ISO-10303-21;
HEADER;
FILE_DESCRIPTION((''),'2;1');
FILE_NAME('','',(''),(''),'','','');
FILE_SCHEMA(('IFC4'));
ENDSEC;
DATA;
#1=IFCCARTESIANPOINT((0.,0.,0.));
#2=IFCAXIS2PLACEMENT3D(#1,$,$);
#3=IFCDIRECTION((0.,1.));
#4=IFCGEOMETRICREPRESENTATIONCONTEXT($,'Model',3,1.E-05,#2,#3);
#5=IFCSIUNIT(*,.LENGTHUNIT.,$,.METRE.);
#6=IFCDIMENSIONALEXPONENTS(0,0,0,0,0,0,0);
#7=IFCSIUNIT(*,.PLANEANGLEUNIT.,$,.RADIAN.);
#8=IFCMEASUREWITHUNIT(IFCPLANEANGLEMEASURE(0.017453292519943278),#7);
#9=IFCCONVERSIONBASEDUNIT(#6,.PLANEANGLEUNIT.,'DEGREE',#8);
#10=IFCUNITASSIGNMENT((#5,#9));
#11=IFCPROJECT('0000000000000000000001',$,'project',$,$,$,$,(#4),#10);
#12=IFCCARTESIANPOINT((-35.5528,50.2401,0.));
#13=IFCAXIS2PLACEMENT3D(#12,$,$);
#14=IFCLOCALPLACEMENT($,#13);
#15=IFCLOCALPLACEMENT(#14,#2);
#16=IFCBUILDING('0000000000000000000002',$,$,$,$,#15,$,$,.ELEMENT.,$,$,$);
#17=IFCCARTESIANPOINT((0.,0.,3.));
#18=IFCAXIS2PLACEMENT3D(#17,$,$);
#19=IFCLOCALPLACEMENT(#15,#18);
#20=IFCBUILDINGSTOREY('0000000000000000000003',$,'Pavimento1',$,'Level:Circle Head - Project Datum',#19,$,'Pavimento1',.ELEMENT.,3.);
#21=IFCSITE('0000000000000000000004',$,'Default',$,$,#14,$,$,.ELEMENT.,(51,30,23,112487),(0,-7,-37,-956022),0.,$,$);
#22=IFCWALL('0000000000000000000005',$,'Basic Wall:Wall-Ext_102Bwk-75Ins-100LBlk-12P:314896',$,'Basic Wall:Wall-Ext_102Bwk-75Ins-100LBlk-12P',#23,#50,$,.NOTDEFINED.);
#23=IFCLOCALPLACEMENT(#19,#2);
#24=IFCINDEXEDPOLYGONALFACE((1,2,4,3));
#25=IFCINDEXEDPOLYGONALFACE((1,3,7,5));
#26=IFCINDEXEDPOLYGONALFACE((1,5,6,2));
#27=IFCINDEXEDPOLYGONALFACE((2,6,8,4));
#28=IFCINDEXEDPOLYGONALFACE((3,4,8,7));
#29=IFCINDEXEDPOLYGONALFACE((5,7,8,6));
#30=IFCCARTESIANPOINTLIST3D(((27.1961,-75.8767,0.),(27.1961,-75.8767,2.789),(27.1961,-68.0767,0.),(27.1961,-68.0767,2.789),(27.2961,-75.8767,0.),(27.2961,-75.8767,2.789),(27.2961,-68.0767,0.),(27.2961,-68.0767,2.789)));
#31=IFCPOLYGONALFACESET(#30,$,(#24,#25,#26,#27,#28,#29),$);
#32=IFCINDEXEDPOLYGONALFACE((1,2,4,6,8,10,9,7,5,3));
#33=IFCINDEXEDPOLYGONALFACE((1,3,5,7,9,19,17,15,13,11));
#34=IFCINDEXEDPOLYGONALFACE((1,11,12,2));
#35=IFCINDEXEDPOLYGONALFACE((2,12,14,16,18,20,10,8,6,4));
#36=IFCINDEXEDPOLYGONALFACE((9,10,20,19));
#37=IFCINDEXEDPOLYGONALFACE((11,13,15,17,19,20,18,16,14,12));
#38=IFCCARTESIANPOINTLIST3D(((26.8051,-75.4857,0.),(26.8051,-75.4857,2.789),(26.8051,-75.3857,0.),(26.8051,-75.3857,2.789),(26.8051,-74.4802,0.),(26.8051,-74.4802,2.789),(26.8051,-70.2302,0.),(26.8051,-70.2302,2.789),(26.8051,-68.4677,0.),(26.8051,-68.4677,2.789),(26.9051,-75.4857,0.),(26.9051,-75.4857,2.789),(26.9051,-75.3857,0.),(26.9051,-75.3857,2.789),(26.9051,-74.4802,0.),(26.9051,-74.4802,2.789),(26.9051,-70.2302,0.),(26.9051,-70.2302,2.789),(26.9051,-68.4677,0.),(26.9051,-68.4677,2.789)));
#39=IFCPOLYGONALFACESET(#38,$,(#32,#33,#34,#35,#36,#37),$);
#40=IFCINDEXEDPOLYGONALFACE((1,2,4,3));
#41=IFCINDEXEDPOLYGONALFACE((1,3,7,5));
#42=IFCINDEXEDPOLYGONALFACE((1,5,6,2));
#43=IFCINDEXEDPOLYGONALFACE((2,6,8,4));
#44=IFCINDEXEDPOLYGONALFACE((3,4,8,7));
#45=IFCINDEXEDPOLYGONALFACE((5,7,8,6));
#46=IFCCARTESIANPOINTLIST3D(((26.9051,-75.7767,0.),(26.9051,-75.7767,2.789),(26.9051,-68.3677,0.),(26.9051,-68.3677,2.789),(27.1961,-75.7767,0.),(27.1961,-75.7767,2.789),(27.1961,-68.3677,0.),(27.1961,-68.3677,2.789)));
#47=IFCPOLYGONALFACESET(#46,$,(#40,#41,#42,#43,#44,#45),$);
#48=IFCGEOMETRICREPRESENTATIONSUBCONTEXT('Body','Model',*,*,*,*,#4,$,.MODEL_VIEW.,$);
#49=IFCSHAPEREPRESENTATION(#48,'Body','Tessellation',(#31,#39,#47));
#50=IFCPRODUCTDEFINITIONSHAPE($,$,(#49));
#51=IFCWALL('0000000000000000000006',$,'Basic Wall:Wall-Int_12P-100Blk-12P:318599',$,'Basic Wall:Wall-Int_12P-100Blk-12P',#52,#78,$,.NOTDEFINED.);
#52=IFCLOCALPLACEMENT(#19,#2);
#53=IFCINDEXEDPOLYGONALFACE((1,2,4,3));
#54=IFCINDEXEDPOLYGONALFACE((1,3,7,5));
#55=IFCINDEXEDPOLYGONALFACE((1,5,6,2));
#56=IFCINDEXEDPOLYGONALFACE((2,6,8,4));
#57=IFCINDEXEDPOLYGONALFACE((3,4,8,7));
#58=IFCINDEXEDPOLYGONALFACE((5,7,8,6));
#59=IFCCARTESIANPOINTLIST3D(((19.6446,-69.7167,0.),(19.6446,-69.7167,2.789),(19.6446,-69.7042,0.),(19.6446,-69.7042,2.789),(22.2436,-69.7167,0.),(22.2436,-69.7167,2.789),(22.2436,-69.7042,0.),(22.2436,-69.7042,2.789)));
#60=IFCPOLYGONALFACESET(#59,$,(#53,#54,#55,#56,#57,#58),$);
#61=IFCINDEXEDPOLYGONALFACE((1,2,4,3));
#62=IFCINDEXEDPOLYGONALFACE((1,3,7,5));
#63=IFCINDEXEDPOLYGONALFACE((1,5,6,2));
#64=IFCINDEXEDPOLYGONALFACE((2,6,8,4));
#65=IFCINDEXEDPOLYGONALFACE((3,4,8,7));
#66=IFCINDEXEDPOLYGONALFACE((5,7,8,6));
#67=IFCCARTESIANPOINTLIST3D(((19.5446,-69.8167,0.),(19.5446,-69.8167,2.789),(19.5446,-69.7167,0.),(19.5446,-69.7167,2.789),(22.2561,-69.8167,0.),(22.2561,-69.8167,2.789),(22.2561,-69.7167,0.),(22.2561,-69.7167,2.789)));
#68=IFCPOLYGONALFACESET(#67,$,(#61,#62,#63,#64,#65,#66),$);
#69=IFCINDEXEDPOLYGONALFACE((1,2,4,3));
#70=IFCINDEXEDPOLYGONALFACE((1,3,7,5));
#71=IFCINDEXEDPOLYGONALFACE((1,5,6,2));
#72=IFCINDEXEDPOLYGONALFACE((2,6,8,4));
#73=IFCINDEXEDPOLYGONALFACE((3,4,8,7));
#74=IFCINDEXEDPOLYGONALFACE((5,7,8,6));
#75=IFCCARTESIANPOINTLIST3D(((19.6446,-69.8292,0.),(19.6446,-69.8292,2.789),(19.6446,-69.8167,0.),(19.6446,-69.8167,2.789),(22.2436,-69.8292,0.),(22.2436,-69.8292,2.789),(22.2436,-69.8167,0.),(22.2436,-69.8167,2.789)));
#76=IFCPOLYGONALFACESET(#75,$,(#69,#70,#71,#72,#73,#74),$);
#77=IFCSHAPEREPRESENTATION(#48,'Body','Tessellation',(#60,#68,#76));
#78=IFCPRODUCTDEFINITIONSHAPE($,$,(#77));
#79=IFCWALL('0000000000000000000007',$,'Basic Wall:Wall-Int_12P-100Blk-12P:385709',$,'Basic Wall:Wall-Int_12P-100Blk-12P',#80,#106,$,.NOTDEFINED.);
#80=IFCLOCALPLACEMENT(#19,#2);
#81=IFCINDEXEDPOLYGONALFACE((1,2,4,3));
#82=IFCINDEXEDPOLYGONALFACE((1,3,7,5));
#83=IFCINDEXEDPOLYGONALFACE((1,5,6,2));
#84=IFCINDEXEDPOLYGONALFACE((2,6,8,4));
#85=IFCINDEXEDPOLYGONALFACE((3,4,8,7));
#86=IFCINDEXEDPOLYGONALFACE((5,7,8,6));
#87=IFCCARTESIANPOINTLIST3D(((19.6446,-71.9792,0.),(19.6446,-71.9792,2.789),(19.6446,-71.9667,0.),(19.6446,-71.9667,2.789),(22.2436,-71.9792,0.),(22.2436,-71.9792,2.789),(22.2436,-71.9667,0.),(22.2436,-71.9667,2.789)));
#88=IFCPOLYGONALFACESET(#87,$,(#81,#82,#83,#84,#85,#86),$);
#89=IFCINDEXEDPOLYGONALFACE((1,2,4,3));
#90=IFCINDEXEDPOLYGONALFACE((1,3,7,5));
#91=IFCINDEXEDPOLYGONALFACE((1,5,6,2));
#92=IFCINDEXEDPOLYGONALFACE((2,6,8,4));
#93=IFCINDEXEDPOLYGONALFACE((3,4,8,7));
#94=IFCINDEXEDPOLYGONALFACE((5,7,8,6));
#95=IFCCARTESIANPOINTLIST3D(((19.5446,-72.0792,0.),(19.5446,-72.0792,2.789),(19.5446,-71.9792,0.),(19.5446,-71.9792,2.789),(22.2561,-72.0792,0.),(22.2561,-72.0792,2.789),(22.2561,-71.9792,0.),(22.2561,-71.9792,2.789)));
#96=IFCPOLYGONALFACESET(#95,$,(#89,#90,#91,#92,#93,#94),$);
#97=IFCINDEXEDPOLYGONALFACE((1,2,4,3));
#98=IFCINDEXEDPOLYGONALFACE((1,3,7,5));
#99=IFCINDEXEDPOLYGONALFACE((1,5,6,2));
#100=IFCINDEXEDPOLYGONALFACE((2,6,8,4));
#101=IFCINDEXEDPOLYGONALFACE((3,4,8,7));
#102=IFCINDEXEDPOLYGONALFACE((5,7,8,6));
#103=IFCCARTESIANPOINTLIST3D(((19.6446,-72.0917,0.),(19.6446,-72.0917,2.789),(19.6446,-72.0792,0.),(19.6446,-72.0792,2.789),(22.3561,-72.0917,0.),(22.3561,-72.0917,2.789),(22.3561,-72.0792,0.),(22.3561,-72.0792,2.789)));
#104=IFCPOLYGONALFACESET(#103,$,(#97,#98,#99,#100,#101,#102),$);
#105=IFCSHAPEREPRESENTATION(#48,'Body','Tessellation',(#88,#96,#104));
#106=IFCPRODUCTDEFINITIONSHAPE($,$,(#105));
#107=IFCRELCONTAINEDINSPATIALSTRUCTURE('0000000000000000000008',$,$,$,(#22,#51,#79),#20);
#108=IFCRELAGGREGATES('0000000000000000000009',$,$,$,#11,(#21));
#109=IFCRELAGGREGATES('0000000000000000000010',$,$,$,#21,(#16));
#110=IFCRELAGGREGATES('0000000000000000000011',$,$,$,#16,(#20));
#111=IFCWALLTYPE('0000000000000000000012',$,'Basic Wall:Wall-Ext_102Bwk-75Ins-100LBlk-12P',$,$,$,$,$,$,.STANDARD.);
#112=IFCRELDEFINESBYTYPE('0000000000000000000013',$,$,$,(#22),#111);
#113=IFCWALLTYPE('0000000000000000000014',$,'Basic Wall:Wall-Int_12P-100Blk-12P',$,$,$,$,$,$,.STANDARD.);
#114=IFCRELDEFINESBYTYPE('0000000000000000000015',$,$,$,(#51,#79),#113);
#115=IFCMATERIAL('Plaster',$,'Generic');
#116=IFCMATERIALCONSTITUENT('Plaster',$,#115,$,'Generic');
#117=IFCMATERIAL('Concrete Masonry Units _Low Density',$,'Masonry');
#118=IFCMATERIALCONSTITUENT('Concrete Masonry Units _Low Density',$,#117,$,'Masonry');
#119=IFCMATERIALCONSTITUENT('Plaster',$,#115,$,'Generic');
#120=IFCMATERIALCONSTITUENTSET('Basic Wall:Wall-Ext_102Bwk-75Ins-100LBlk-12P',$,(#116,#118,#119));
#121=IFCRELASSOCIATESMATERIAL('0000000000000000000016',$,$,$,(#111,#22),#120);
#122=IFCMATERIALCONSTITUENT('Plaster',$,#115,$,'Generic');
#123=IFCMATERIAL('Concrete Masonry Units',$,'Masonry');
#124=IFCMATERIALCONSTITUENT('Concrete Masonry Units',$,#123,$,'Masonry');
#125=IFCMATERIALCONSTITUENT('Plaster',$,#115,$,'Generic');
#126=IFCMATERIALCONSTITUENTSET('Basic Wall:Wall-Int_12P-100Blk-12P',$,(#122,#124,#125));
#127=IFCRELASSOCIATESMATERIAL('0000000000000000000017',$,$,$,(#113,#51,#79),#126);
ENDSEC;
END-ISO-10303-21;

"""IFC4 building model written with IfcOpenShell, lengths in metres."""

from ifc_helpers import new_model, entity, si_unit, converted_unit, direction, frame, origin, place, context, subcontext, project, spatial, indexed_curve, outline, extrude, material, constituent, constituent_set, type_object, element, save


model = new_model("IFC4")

# Units and contexts
model_context = context("Model", 3, precision=1e-05, world=origin(), true_north=direction((0.0, 1.0)))
body_context = subcontext(model_context, "Body", "Model", "MODEL_VIEW")
ifc_project = project(units=[si_unit("LENGTHUNIT", "METRE"), converted_unit("PLANEANGLEUNIT", "DEGREE", entity("IfcPlaneAngleMeasure", 0.017453292519943278), si_unit("PLANEANGLEUNIT", "RADIAN"), dimensions=[0, 0, 0, 0, 0, 0, 0])], contexts=[model_context])

# Site, building, storey
site_placement = place(None, frame((-35.5528, 50.2401, 0.0)))
site = spatial("IfcSite", under=ifc_project, at=site_placement, Name="Default", CompositionType="ELEMENT", RefLatitude=(51, 30, 23, 112487), RefLongitude=(0, -7, -37, -956022), RefElevation=0.0)
building_placement = place(site_placement, origin())
building = spatial("IfcBuilding", under=site, at=building_placement, CompositionType="ELEMENT")
storey_placement = place(building_placement, frame((0.0, 0.0, 3.0)))
storey = spatial("IfcBuildingStorey", under=building, at=storey_placement, Name="Pavimento1", ObjectType="Level:Circle Head - Project Datum", LongName="Pavimento1", CompositionType="ELEMENT", Elevation=3.0)

# Wall
ifc_material_1 = material(Name="Plaster", Category="Generic")
ifc_constituent_1 = constituent(ifc_material_1, Name="Plaster", Category="Generic")
ifc_material_2 = material(Name="Concrete Masonry Units _Low Density", Category="Masonry")
ifc_constituent_2 = constituent(ifc_material_2, Name="Concrete Masonry Units _Low Density", Category="Masonry")
ifc_constituent_3 = constituent(ifc_material_1, Name="Plaster", Category="Generic")
ifc_constituent_set_1 = constituent_set(constituents=[ifc_constituent_1, ifc_constituent_2, ifc_constituent_3], Name="Basic Wall:Wall-Ext_102Bwk-75Ins-100LBlk-12P")
wall_type_1 = type_object("IfcWallType", Name="Basic Wall:Wall-Ext_102Bwk-75Ins-100LBlk-12P", PredefinedType="STANDARD", material=ifc_constituent_set_1)
wall_1_placement = place(storey_placement, frame((27.0506, -68.4677, 0.0), z_axis=(0.0, 0.0, 1.0), x_axis=(0.0, -1.0, 0.0)))
element("IfcWall", 1, at=wall_1_placement, inside=storey, type_object=wall_type_1, material=ifc_constituent_set_1, Name="Basic Wall:Wall-Ext_102Bwk-75Ins-100LBlk-12P:314896", ObjectType="Basic Wall:Wall-Ext_102Bwk-75Ins-100LBlk-12P", PredefinedType="NOTDEFINED", context=body_context, shape_type="SweptSolid", body=[
    extrude(outline(indexed_curve([(-1.3945, -3.9), (1.3945, -3.9), (1.3945, 3.9), (-1.3945, 3.9), (-1.3945, -3.9)], self_intersect=False)), frame((3.509, 0.1455, 1.3945), z_axis=(0.0, 1.0, 0.0), x_axis=(0.0, 0.0, 1.0)), (0.0, 0.0, 1.0), 0.1),
    extrude(outline(indexed_curve([(-1.3945, -4.3422), (1.3945, -4.3422), (1.3945, -2.5797), (1.3945, 1.6703), (1.3945, 2.5758), (1.3945, 2.6758), (-1.3945, 2.6758), (-1.3945, 2.5758), (-1.3945, 1.6703), (-1.3945, -2.5797), (-1.3945, -4.3422)], self_intersect=False)), frame((4.3422, -0.2455, 1.3945), z_axis=(0.0, 1.0, 0.0), x_axis=(0.0, 0.0, 1.0)), (0.0, 0.0, 1.0), 0.1),
    extrude(outline(indexed_curve([(-1.3945, -3.7045), (1.3945, -3.7045), (1.3945, 3.7045), (-1.3945, 3.7045), (-1.3945, -3.7045)], self_intersect=False)), frame((3.6045, -0.1455, 1.3945), z_axis=(0.0, 1.0, 0.0), x_axis=(0.0, 0.0, 1.0)), (0.0, 0.0, 1.0), 0.291),
])

# Shared definitions
ifc_constituent_4 = constituent(ifc_material_1, Name="Plaster", Category="Generic")
ifc_material_3 = material(Name="Concrete Masonry Units", Category="Masonry")
ifc_constituent_5 = constituent(ifc_material_3, Name="Concrete Masonry Units", Category="Masonry")
ifc_constituent_6 = constituent(ifc_material_1, Name="Plaster", Category="Generic")
ifc_constituent_set_2 = constituent_set(constituents=[ifc_constituent_4, ifc_constituent_5, ifc_constituent_6], Name="Basic Wall:Wall-Int_12P-100Blk-12P")
wall_type_2 = type_object("IfcWallType", Name="Basic Wall:Wall-Int_12P-100Blk-12P", PredefinedType="STANDARD", material=ifc_constituent_set_2)

# Wall
wall_2_placement = place(storey_placement, frame((22.2436, -69.7667, 0.0), z_axis=(0.0, 0.0, 1.0), x_axis=(-1.0, 0.0, 0.0)))
element("IfcWall", 2, at=wall_2_placement, inside=storey, type_object=wall_type_2, material=ifc_constituent_set_2, Name="Basic Wall:Wall-Int_12P-100Blk-12P:318599", ObjectType="Basic Wall:Wall-Int_12P-100Blk-12P", PredefinedType="NOTDEFINED", context=body_context, shape_type="SweptSolid", body=[
    extrude(outline(indexed_curve([(-0.0063, -1.2995), (0.0062, -1.2995), (0.0062, 1.2995), (-0.0063, 1.2995), (-0.0063, -1.2995)], self_intersect=False)), frame((1.2995, -0.0562, 0.0), z_axis=(0.0, 0.0, 1.0), x_axis=(0.0, 1.0, 0.0)), (0.0, 0.0, 1.0), 2.789),
    extrude(outline(indexed_curve([(-1.3557, -0.05), (1.3558, -0.05), (1.3558, 0.05), (-1.3557, 0.05), (-1.3557, -0.05)], self_intersect=False)), frame((1.3432, 0.0, 0.0)), (0.0, 0.0, 1.0), 2.789),
    extrude(outline(indexed_curve([(-0.0063, -1.2995), (0.0063, -1.2995), (0.0063, 1.2995), (-0.0062, 1.2995), (-0.0063, -1.2995)], self_intersect=False)), frame((1.2995, 0.0563, 0.0), z_axis=(0.0, 0.0, 1.0), x_axis=(0.0, -1.0, 0.0)), (0.0, 0.0, 1.0), 2.789),
])

# Wall
wall_3_placement = place(storey_placement, frame((22.2436, -72.0292, 0.0), z_axis=(0.0, 0.0, 1.0), x_axis=(-1.0, 0.0, 0.0)))
element("IfcWall", 3, at=wall_3_placement, inside=storey, type_object=wall_type_2, material=ifc_constituent_set_2, Name="Basic Wall:Wall-Int_12P-100Blk-12P:385709", ObjectType="Basic Wall:Wall-Int_12P-100Blk-12P", PredefinedType="NOTDEFINED", context=body_context, shape_type="SweptSolid", body=[
    extrude(outline(indexed_curve([(-0.0063, -1.2995), (0.0062, -1.2995), (0.0063, 1.2995), (-0.0062, 1.2995), (-0.0063, -1.2995)], self_intersect=False)), frame((1.2995, -0.0563, 0.0), z_axis=(0.0, 0.0, 1.0), x_axis=(0.0, 1.0, 0.0)), (0.0, 0.0, 1.0), 2.789),
    extrude(outline(indexed_curve([(-1.3558, -0.05), (1.3557, -0.05), (1.3557, 0.05), (-1.3558, 0.05), (-1.3558, -0.05)], self_intersect=False)), frame((1.3433, 0.0, 0.0)), (0.0, 0.0, 1.0), 2.789),
    extrude(outline(indexed_curve([(-0.0063, -1.3558), (0.0062, -1.3558), (0.0063, 1.3557), (-0.0063, 1.3557), (-0.0063, -1.3558)], self_intersect=False)), frame((1.2433, 0.0562, 0.0), z_axis=(0.0, 0.0, 1.0), x_axis=(0.0, -1.0, 0.0)), (0.0, 0.0, 1.0), 2.789),
])

save(model, "model.ifc")
